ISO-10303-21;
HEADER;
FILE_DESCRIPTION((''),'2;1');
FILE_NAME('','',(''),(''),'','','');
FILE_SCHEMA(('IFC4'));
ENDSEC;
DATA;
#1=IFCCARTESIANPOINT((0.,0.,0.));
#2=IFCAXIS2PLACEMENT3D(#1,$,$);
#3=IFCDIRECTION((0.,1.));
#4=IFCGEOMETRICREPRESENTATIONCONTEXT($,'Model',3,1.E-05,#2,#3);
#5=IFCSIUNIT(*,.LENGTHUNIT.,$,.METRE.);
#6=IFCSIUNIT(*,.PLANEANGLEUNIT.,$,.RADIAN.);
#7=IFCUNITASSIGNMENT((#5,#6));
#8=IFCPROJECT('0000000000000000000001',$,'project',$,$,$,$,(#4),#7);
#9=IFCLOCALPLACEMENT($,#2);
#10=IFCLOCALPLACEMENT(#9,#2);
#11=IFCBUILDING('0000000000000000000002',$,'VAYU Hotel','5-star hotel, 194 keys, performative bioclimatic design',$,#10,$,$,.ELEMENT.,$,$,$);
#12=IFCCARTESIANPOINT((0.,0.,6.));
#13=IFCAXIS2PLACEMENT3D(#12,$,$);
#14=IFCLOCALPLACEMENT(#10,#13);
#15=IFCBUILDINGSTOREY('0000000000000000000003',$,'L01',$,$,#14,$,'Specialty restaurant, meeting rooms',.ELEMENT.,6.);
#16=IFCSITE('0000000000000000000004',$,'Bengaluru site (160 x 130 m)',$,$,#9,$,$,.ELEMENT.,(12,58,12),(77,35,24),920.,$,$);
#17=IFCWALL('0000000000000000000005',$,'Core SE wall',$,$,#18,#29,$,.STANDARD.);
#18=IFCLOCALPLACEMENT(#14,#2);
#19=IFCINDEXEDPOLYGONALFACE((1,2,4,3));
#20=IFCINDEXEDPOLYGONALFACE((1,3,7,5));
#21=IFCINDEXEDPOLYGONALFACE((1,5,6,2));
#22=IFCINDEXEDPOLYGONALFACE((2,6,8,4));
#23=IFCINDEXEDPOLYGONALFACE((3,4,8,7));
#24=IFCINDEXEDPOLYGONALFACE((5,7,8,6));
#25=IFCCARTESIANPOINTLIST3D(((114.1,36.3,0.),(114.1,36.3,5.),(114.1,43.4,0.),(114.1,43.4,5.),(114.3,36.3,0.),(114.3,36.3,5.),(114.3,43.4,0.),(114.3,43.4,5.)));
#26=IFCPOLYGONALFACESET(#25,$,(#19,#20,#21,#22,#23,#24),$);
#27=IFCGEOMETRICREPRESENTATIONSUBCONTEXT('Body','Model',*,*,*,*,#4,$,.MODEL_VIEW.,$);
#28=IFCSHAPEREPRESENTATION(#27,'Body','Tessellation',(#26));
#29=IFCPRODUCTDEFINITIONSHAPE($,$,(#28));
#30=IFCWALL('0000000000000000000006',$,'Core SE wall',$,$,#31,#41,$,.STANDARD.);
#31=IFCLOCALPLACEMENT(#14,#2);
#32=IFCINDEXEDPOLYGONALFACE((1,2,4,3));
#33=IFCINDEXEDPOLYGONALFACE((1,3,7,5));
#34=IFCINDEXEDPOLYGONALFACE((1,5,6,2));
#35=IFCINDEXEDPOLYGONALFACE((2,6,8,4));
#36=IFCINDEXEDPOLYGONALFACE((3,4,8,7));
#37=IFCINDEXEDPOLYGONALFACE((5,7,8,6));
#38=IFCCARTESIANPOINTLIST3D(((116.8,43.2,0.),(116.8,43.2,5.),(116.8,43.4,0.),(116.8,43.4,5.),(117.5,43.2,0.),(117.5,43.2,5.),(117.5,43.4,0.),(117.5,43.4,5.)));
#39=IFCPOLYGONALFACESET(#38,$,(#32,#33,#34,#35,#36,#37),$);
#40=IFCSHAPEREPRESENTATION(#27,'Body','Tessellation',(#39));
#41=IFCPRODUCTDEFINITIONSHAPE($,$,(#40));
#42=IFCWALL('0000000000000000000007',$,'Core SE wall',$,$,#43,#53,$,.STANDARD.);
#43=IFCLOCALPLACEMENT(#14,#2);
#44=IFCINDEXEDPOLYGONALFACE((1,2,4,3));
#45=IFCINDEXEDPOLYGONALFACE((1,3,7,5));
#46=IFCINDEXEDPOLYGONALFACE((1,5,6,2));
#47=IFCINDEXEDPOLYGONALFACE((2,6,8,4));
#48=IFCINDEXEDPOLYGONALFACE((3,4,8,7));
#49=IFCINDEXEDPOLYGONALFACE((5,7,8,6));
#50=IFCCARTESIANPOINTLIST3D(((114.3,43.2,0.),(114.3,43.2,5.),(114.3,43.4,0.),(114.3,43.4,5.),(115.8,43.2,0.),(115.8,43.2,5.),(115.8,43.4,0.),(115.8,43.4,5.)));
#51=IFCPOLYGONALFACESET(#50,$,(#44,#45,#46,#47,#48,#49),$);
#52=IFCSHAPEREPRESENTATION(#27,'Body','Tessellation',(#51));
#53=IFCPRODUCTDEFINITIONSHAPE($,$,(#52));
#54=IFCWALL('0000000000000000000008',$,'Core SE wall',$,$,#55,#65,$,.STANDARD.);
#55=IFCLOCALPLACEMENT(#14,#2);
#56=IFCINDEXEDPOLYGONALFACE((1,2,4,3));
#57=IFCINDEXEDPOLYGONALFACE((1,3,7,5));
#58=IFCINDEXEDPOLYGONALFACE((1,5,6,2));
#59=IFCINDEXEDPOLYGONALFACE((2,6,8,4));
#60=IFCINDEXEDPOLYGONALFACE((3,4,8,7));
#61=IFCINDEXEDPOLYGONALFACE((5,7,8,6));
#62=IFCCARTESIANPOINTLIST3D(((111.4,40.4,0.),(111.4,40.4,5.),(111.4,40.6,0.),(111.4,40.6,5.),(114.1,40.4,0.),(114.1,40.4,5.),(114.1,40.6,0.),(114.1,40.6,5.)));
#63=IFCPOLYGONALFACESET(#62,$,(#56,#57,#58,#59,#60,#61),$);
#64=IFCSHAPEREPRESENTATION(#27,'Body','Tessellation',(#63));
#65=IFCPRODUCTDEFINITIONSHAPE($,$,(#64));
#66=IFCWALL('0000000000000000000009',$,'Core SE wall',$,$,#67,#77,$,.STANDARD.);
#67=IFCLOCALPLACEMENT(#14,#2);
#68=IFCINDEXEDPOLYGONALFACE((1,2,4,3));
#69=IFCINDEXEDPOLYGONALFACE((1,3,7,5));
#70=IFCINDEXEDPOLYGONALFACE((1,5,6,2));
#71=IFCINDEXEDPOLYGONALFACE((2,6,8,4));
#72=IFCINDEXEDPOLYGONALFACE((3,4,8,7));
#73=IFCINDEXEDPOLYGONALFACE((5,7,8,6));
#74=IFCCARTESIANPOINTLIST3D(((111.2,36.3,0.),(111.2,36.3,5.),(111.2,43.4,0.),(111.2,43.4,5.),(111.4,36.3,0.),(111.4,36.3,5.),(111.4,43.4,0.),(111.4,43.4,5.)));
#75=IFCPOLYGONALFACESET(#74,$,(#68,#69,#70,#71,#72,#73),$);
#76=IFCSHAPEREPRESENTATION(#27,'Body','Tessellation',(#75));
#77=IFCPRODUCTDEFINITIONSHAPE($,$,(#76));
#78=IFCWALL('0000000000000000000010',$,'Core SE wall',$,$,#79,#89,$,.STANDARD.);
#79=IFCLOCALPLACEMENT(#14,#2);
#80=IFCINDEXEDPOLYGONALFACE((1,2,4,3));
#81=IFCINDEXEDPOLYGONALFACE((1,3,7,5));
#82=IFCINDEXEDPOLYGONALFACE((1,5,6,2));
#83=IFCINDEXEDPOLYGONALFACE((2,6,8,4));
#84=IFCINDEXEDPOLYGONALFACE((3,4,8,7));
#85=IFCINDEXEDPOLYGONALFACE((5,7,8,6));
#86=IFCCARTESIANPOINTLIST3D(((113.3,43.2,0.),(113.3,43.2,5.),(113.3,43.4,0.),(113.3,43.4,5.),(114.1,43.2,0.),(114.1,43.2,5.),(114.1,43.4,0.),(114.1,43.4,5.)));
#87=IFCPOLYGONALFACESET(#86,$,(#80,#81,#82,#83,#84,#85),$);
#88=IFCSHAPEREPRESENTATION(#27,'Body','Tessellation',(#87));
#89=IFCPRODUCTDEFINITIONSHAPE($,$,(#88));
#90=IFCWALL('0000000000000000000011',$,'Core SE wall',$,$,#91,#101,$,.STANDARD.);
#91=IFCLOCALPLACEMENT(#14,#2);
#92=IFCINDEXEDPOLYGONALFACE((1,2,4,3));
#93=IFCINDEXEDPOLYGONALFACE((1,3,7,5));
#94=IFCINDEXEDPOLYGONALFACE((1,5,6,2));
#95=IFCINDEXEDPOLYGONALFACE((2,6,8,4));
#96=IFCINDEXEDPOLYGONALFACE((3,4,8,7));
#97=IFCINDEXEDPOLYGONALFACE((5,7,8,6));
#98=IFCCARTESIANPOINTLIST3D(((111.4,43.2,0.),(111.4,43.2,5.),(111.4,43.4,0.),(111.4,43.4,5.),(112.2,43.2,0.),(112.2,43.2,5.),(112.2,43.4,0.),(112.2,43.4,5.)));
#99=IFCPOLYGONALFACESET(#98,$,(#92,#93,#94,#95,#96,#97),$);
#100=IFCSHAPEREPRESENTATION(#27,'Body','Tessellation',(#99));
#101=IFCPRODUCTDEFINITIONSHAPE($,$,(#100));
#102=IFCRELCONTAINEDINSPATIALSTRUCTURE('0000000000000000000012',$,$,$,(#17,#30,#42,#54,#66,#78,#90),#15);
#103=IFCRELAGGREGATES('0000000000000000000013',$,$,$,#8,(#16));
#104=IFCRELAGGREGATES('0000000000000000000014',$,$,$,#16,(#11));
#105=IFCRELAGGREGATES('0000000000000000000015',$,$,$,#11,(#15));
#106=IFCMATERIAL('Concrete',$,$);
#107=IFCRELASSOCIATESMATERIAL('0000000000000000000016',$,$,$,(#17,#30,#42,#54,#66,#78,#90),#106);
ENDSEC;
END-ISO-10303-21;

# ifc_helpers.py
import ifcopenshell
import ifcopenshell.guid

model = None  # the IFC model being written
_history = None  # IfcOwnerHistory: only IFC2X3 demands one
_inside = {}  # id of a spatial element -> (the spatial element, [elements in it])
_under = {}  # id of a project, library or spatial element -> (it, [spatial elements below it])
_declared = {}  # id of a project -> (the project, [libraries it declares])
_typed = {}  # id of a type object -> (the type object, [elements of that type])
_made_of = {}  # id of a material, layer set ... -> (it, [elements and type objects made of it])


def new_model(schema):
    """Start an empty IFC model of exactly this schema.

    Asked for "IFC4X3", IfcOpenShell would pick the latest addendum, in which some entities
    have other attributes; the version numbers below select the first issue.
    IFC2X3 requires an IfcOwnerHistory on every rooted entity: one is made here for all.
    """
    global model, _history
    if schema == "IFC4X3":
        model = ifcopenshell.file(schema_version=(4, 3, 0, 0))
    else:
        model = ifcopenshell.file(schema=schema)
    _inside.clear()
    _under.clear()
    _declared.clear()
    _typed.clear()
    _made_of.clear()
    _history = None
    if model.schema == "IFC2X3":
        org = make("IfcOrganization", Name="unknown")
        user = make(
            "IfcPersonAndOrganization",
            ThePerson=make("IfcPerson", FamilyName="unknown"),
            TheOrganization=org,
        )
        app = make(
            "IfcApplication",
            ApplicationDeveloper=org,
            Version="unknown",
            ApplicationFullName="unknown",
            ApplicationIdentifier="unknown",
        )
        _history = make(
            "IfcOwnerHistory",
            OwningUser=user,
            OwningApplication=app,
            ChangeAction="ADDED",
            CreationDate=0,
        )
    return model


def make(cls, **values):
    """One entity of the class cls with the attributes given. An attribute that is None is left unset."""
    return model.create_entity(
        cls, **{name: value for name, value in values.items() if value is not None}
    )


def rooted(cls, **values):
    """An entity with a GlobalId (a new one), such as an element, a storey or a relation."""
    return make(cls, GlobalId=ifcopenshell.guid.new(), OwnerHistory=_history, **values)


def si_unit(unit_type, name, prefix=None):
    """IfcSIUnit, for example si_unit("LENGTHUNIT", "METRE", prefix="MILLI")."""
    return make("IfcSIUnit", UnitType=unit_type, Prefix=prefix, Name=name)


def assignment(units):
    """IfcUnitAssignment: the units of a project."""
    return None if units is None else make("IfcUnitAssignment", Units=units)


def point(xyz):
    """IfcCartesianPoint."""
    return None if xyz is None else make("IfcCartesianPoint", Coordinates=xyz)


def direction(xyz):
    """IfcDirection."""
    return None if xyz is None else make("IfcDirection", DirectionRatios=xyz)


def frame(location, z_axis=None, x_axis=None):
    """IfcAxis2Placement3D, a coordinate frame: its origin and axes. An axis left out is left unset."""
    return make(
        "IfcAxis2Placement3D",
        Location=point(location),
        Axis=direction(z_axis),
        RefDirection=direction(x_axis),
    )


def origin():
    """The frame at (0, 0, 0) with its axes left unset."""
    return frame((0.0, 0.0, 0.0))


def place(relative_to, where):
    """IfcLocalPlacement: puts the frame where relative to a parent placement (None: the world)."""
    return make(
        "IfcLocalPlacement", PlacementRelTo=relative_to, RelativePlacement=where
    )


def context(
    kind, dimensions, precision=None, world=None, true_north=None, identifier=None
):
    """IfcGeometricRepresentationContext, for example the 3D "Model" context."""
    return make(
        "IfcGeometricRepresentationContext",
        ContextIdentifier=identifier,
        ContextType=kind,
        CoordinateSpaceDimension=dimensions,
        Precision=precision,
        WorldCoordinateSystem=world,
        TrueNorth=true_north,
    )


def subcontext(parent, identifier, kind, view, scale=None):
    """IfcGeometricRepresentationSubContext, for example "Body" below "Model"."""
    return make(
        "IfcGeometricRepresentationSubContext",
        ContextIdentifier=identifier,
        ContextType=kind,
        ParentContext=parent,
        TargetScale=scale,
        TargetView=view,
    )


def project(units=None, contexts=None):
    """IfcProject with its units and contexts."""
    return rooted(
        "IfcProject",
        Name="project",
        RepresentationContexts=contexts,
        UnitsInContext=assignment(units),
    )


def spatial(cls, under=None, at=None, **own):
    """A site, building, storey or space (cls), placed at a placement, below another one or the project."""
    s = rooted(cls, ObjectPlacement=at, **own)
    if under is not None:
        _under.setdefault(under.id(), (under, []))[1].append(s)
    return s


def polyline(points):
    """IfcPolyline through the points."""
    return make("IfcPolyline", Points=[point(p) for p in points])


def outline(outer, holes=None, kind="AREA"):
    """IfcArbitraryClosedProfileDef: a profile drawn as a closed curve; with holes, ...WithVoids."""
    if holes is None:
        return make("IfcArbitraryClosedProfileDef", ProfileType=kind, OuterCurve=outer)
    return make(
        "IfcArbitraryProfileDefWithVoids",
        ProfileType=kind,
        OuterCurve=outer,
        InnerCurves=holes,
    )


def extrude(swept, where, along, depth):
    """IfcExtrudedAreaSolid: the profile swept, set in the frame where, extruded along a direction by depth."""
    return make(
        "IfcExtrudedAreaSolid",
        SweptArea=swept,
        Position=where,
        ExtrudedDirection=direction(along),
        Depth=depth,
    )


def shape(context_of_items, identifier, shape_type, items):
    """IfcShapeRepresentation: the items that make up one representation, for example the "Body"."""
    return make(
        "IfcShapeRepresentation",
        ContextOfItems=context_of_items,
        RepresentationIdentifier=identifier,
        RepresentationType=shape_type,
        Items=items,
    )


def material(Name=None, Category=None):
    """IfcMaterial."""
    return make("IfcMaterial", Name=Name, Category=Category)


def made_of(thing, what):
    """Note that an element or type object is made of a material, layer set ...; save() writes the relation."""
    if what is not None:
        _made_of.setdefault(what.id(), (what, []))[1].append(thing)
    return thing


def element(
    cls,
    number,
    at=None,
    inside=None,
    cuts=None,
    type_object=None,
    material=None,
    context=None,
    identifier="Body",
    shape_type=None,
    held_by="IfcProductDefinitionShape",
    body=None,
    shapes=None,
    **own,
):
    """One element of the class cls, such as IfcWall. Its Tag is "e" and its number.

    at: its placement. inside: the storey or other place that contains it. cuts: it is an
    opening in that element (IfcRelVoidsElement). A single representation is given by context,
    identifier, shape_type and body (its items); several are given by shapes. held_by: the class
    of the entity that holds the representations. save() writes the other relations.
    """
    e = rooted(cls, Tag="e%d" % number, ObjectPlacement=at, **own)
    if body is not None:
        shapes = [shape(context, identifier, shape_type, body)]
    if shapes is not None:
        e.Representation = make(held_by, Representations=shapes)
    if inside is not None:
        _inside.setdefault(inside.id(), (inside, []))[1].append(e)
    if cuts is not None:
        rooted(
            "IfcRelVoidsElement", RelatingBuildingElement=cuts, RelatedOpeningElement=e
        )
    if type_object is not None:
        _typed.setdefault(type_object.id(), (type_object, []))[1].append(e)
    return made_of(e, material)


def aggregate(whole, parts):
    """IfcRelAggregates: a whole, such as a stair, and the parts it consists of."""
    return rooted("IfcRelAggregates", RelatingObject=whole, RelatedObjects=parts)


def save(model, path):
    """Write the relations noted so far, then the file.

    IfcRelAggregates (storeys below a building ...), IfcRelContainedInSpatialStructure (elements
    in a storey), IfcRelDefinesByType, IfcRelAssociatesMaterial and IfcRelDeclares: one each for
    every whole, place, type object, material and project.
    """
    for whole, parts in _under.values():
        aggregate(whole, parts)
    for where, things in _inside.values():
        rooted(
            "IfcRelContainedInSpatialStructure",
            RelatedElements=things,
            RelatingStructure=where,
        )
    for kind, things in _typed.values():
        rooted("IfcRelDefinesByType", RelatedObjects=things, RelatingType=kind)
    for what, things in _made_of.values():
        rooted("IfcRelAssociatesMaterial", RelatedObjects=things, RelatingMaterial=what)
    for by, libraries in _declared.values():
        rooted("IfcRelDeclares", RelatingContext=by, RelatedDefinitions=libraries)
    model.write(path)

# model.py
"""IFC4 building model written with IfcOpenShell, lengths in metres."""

from ifc_helpers import new_model, si_unit, direction, frame, origin, place, context, subcontext, project, spatial, polyline, outline, extrude, material, element, save


model = new_model("IFC4")

# Units and contexts
model_context = context("Model", 3, precision=1e-05, world=origin(), true_north=direction((0.0, 1.0)))
body_context = subcontext(model_context, "Body", "Model", "MODEL_VIEW")
ifc_project = project(units=[si_unit("LENGTHUNIT", "METRE"), si_unit("PLANEANGLEUNIT", "RADIAN")], contexts=[model_context])

# Site, building, storey
site_placement = place(None, origin())
site = spatial("IfcSite", under=ifc_project, at=site_placement, Name="Bengaluru site (160 x 130 m)", CompositionType="ELEMENT", RefLatitude=(12, 58, 12), RefLongitude=(77, 35, 24), RefElevation=920.0)
building_placement = place(site_placement, origin())
building = spatial("IfcBuilding", under=site, at=building_placement, Name="VAYU Hotel", Description="5-star hotel, 194 keys, performative bioclimatic design", CompositionType="ELEMENT")
storey_placement = place(building_placement, frame((0.0, 0.0, 6.0)))
storey = spatial("IfcBuildingStorey", under=building, at=storey_placement, Name="L01", LongName="Specialty restaurant, meeting rooms", CompositionType="ELEMENT", Elevation=6.0)

# Walls
ifc_material = material(Name="Concrete")
wall_1_placement = place(storey_placement, origin())
element("IfcWall", 1, at=wall_1_placement, inside=storey, material=ifc_material, Name="Core SE wall", PredefinedType="STANDARD", context=body_context, shape_type="SweptSolid", body=[
    extrude(outline(polyline([(114.1, 36.3), (114.1, 43.4), (114.3, 43.4), (114.3, 36.3), (114.1, 36.3)])), origin(), (0.0, 0.0, 1.0), 5.0),
])
wall_2_placement = place(storey_placement, origin())
element("IfcWall", 2, at=wall_2_placement, inside=storey, material=ifc_material, Name="Core SE wall", PredefinedType="STANDARD", context=body_context, shape_type="SweptSolid", body=[
    extrude(outline(polyline([(116.8, 43.4), (117.5, 43.4), (117.5, 43.2), (116.8, 43.2), (116.8, 43.4)])), origin(), (0.0, 0.0, 1.0), 5.0),
])
wall_3_placement = place(storey_placement, origin())
element("IfcWall", 3, at=wall_3_placement, inside=storey, material=ifc_material, Name="Core SE wall", PredefinedType="STANDARD", context=body_context, shape_type="SweptSolid", body=[
    extrude(outline(polyline([(114.3, 43.4), (115.8, 43.4), (115.8, 43.2), (114.3, 43.2), (114.3, 43.4)])), origin(), (0.0, 0.0, 1.0), 5.0),
])
wall_4_placement = place(storey_placement, origin())
element("IfcWall", 4, at=wall_4_placement, inside=storey, material=ifc_material, Name="Core SE wall", PredefinedType="STANDARD", context=body_context, shape_type="SweptSolid", body=[
    extrude(outline(polyline([(111.4, 40.6), (114.1, 40.6), (114.1, 40.4), (111.4, 40.4), (111.4, 40.6)])), origin(), (0.0, 0.0, 1.0), 5.0),
])
wall_5_placement = place(storey_placement, origin())
element("IfcWall", 5, at=wall_5_placement, inside=storey, material=ifc_material, Name="Core SE wall", PredefinedType="STANDARD", context=body_context, shape_type="SweptSolid", body=[
    extrude(outline(polyline([(111.2, 36.3), (111.2, 43.4), (111.4, 43.4), (111.4, 36.3), (111.2, 36.3)])), origin(), (0.0, 0.0, 1.0), 5.0),
])
wall_6_placement = place(storey_placement, origin())
element("IfcWall", 6, at=wall_6_placement, inside=storey, material=ifc_material, Name="Core SE wall", PredefinedType="STANDARD", context=body_context, shape_type="SweptSolid", body=[
    extrude(outline(polyline([(113.3, 43.4), (114.1, 43.4), (114.1, 43.2), (113.3, 43.2), (113.3, 43.4)])), origin(), (0.0, 0.0, 1.0), 5.0),
])
wall_7_placement = place(storey_placement, origin())
element("IfcWall", 7, at=wall_7_placement, inside=storey, material=ifc_material, Name="Core SE wall", PredefinedType="STANDARD", context=body_context, shape_type="SweptSolid", body=[
    extrude(outline(polyline([(111.4, 43.4), (112.2, 43.4), (112.2, 43.2), (111.4, 43.2), (111.4, 43.4)])), origin(), (0.0, 0.0, 1.0), 5.0),
])

save(model, "model.ifc")
